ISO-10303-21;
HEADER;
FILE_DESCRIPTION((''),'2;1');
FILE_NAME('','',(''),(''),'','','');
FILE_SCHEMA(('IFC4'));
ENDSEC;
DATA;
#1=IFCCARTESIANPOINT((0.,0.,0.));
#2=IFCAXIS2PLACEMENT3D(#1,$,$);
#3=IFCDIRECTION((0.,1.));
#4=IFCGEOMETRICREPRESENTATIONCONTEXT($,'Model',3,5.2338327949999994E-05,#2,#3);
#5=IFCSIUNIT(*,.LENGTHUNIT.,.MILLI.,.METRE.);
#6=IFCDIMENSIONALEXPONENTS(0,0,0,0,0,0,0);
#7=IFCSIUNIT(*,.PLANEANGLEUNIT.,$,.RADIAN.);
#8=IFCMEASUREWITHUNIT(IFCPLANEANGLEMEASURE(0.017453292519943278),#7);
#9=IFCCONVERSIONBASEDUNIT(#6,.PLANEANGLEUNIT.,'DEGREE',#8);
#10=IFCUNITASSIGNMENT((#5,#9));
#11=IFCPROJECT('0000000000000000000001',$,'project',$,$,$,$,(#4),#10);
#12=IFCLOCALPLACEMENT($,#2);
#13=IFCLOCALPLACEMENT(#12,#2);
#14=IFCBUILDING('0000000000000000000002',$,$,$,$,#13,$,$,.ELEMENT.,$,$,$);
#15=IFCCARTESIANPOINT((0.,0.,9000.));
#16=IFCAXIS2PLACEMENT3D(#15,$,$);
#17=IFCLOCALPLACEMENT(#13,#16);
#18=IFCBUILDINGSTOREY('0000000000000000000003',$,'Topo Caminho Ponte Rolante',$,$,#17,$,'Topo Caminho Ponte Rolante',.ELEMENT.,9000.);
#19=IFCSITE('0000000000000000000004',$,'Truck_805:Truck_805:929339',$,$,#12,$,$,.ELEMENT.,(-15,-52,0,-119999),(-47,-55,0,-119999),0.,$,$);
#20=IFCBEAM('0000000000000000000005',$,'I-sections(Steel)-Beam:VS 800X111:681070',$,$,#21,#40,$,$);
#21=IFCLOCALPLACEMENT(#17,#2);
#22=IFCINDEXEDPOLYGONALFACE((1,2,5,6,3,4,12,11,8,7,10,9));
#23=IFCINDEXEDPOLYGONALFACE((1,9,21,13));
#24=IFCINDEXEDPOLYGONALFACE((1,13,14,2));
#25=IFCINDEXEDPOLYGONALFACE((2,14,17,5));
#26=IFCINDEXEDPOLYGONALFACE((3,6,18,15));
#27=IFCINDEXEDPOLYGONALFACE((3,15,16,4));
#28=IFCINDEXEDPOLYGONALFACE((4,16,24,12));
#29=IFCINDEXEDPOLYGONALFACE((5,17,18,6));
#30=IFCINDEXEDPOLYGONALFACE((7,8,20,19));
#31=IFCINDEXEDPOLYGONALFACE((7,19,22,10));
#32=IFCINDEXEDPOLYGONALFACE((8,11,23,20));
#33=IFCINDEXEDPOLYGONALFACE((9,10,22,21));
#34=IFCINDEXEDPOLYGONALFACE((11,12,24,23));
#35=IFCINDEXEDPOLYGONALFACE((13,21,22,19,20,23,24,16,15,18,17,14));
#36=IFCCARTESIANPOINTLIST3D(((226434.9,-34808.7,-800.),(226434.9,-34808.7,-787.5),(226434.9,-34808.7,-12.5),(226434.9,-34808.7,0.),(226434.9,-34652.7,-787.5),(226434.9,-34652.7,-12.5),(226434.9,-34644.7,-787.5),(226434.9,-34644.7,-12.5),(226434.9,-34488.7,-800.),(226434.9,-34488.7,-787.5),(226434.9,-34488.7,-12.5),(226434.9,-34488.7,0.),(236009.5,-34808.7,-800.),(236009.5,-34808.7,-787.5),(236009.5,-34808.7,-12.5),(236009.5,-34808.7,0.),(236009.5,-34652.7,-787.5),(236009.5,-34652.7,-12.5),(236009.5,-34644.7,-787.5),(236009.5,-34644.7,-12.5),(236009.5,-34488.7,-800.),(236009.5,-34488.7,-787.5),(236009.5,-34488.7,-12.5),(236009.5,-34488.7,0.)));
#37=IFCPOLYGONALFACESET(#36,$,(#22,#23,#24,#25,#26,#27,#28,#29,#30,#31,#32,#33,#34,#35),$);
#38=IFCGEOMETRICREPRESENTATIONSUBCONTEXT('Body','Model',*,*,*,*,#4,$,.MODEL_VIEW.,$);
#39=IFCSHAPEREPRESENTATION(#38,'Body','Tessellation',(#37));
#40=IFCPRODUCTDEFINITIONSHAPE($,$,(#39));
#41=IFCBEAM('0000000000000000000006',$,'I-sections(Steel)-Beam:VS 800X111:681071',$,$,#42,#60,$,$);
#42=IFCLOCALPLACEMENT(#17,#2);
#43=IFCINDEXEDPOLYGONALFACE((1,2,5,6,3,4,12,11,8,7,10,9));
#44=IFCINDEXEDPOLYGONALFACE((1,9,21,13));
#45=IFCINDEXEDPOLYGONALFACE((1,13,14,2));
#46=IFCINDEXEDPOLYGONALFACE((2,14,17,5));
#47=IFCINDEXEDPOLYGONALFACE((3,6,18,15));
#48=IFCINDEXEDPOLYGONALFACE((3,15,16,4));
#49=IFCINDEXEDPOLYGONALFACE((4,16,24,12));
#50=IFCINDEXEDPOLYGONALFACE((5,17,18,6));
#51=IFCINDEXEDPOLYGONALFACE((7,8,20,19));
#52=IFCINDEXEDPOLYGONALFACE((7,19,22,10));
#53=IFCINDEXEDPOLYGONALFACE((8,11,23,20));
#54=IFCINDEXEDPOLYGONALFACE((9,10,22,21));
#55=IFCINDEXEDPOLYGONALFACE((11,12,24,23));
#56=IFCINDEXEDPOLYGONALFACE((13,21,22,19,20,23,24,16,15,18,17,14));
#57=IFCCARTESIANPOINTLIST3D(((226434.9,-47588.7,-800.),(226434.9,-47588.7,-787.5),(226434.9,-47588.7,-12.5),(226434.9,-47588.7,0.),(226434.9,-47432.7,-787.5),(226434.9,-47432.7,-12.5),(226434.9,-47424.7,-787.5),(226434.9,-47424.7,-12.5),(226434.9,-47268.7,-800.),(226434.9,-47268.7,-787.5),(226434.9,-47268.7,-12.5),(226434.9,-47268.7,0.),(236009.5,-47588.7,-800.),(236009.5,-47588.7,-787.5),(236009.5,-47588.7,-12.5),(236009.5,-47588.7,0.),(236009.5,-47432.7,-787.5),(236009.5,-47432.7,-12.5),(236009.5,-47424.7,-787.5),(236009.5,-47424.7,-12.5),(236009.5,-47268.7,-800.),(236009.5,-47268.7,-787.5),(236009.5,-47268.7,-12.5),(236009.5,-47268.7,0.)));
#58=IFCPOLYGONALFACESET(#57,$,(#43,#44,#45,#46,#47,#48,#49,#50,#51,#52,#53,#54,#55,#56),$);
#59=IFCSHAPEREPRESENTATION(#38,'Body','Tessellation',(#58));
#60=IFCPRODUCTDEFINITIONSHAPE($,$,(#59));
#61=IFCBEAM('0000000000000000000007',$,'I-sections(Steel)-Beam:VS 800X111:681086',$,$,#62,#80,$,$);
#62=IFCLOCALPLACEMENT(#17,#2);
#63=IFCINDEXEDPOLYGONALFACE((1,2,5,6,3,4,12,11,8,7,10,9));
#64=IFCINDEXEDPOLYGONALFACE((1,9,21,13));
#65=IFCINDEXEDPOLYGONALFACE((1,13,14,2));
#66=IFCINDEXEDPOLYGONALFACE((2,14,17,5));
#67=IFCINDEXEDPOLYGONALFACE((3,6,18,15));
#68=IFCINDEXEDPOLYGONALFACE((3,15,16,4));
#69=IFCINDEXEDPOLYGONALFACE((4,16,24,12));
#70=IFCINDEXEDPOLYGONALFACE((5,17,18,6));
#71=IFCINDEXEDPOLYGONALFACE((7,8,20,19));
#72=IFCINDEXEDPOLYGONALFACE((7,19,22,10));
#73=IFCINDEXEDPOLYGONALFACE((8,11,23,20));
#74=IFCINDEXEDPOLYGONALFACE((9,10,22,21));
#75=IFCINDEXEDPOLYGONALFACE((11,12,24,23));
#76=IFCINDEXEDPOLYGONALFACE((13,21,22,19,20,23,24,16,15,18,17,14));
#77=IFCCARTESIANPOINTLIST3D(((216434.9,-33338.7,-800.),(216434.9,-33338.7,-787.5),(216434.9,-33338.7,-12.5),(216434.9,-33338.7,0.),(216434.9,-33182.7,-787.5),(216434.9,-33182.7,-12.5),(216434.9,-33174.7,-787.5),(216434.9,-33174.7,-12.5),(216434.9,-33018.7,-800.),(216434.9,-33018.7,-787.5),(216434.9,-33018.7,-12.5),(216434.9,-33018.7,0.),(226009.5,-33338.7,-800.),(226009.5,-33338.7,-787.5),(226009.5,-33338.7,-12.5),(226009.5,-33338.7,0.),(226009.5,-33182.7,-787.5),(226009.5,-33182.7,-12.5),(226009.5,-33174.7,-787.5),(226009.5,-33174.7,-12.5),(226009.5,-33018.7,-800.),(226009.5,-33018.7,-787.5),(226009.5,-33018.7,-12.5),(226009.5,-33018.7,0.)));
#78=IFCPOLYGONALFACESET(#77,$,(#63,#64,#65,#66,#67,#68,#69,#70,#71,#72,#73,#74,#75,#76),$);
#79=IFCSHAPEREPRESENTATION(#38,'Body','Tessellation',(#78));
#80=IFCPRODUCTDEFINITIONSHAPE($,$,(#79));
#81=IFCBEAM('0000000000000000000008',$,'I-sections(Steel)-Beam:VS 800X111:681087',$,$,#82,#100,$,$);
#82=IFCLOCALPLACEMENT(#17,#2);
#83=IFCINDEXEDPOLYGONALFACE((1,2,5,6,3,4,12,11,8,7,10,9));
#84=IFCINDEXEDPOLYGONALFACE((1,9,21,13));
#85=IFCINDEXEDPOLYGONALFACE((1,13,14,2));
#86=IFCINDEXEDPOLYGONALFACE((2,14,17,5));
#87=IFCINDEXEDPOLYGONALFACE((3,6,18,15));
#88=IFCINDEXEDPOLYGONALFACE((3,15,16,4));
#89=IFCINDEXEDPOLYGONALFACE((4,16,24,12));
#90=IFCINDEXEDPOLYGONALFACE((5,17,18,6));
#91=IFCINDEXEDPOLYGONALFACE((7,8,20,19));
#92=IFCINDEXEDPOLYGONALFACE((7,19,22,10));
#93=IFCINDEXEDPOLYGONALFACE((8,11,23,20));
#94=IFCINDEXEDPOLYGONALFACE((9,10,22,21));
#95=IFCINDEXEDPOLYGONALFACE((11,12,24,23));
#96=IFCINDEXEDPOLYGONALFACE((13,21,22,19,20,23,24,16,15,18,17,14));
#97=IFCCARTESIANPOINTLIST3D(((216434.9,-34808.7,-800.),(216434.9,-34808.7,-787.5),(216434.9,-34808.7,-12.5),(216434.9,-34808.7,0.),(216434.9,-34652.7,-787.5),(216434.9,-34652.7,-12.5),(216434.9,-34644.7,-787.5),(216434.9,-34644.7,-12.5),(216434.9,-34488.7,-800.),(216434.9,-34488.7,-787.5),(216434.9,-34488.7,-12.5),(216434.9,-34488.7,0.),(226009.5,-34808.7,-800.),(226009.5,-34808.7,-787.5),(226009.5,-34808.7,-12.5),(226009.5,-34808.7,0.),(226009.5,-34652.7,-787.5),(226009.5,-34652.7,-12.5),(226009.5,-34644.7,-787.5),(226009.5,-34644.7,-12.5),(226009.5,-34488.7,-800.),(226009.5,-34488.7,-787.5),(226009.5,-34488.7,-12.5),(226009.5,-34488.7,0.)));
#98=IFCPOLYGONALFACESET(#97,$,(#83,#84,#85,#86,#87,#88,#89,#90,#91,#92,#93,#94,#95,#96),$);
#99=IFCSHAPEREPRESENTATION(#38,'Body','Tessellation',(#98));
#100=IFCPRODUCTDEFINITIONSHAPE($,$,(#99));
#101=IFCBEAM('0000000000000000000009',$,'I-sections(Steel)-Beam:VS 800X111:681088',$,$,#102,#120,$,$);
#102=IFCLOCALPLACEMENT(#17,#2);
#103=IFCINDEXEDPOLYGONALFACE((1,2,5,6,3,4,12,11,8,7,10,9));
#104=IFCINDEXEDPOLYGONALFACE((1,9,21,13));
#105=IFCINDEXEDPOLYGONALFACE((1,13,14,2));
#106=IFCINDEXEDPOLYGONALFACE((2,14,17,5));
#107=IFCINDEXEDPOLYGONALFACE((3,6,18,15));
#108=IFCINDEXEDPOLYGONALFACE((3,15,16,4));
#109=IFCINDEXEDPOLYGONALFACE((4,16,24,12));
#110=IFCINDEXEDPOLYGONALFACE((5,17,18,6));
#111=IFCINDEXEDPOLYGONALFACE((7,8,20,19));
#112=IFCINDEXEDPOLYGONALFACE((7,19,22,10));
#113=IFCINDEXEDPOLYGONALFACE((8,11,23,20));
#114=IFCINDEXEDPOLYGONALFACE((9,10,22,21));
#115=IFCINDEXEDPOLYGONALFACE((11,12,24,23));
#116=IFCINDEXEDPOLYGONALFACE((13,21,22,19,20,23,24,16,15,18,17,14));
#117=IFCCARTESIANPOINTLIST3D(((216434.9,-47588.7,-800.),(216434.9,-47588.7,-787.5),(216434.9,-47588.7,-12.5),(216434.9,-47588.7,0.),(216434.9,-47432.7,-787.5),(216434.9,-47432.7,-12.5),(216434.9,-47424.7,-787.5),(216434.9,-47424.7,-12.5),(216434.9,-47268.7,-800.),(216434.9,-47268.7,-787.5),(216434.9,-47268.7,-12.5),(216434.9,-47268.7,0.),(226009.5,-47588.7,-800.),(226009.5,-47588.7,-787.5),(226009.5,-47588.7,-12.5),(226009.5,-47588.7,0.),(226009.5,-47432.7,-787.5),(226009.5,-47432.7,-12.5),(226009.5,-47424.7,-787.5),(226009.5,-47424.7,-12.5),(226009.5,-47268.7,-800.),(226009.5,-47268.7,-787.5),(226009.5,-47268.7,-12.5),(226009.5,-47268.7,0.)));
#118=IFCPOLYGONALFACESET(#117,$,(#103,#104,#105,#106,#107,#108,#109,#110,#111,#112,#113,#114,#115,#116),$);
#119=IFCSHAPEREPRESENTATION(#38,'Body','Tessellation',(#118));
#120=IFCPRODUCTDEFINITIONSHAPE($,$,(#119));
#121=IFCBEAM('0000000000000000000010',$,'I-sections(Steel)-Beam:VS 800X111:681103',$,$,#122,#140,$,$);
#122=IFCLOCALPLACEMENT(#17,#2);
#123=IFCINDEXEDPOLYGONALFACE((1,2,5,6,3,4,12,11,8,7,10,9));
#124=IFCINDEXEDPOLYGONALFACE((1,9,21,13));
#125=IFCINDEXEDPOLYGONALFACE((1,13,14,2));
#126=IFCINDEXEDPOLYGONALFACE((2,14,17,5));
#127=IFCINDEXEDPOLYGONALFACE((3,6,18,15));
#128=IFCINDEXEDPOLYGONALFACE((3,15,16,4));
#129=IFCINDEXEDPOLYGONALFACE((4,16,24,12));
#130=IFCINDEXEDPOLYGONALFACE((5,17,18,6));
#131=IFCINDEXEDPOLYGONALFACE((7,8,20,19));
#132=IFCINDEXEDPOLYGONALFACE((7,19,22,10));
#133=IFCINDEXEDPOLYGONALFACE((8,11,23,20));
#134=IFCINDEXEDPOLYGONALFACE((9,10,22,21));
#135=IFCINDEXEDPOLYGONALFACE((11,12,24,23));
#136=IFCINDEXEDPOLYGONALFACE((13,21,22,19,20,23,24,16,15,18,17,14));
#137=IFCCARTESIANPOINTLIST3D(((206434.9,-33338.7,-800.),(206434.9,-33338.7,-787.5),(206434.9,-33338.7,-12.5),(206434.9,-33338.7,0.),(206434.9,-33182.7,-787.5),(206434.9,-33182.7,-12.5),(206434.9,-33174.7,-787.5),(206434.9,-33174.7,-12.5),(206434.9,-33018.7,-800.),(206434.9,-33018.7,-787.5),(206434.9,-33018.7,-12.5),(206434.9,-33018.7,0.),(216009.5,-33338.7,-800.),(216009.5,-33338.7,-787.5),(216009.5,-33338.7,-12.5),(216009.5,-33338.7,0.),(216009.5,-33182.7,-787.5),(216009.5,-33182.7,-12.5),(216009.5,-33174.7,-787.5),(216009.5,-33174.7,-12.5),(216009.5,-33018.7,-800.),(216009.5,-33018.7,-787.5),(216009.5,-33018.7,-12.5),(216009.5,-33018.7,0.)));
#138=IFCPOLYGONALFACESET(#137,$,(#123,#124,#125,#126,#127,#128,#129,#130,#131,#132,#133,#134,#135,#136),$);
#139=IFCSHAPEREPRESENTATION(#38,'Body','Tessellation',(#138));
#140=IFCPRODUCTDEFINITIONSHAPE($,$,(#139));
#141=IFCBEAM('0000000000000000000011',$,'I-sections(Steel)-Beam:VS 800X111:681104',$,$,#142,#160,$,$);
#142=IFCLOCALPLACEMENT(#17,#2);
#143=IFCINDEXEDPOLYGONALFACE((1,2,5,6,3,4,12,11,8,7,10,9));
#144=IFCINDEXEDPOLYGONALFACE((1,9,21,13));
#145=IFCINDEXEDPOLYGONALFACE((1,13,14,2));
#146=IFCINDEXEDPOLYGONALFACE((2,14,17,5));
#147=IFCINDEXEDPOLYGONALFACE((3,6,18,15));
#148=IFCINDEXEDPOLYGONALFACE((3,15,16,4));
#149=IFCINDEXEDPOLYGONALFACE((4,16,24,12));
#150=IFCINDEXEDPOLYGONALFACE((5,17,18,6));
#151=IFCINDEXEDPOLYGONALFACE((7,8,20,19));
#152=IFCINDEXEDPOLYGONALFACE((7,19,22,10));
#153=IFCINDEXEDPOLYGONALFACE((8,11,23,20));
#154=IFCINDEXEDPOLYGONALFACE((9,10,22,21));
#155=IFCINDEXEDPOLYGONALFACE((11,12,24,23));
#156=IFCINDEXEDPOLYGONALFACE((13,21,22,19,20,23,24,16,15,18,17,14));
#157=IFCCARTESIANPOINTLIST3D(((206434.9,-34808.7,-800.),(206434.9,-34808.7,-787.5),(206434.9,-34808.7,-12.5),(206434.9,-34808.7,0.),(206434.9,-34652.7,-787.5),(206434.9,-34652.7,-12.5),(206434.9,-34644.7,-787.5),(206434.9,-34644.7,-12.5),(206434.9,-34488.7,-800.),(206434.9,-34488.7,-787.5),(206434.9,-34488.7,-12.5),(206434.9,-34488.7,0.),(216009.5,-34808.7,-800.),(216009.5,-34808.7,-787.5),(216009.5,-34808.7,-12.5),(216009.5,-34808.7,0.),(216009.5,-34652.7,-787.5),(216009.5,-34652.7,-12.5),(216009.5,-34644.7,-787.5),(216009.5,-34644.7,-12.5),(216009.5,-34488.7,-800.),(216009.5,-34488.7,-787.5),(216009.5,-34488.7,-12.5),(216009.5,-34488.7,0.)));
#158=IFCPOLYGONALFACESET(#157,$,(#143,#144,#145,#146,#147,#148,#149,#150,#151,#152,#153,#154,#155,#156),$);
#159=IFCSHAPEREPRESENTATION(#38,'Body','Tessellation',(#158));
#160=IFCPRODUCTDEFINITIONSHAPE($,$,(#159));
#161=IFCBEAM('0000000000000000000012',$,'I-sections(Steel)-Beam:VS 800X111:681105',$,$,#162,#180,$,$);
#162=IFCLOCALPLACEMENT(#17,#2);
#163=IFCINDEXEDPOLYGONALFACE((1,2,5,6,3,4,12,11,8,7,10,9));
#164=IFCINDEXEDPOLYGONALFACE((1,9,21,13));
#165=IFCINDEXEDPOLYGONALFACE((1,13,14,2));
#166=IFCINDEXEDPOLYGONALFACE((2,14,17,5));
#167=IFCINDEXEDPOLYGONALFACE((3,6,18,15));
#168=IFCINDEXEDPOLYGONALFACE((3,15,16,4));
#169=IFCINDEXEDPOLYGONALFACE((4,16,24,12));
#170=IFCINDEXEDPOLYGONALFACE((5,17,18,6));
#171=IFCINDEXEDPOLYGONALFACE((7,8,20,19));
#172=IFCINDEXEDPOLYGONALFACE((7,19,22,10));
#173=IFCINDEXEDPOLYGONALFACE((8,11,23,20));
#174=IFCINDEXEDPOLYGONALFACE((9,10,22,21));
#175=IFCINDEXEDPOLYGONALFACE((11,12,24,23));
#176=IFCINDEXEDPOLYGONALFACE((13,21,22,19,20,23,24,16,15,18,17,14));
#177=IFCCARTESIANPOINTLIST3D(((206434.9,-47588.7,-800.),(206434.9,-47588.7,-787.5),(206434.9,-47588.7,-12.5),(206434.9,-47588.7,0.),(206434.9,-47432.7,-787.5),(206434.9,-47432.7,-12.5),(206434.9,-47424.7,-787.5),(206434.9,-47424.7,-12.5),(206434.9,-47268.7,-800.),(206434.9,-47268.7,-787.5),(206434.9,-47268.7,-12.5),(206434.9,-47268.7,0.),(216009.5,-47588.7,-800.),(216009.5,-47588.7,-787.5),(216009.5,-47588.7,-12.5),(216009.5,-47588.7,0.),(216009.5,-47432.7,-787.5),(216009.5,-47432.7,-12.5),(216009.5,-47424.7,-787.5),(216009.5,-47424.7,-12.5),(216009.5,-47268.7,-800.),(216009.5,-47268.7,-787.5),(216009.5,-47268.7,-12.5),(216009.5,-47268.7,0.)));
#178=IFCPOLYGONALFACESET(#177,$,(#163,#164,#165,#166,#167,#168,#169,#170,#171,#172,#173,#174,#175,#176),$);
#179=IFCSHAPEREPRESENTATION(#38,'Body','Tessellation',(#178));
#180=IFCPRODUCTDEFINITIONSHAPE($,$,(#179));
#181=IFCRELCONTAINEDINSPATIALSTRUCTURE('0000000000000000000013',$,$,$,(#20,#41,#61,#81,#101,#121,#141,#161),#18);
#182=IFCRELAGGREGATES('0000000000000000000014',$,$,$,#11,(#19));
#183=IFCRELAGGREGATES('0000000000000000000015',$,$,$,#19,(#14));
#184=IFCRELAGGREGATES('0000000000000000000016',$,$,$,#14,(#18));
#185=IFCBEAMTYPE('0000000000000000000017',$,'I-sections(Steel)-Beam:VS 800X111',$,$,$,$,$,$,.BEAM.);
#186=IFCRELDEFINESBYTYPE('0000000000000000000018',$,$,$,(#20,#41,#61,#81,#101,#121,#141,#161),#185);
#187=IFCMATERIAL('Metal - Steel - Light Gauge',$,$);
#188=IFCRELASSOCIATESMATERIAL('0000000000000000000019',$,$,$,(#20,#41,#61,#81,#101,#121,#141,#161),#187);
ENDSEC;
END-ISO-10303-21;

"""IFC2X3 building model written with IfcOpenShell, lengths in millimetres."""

from ifc_helpers import new_model, entity, si_unit, converted_unit, direction, frame, frame_2d, origin, place, context, subcontext, project, spatial, polyline, i_section, outline, extrude, material, type_object, element, save


model = new_model("IFC2X3")

# Units and contexts
model_context = context("Model", 3, precision=5.2338327949999994e-05, world=origin(), true_north=direction((0.0, 1.0)))
body_context = subcontext(model_context, "Body", "Model", "MODEL_VIEW")
ifc_project = project(units=[si_unit("LENGTHUNIT", "METRE", prefix="MILLI"), converted_unit("PLANEANGLEUNIT", "DEGREE", entity("IfcPlaneAngleMeasure", 0.017453292519943278), si_unit("PLANEANGLEUNIT", "RADIAN"), dimensions=[0, 0, 0, 0, 0, 0, 0])], contexts=[model_context])

# Site, building, storey
site_placement = place(None, origin())
site = spatial("IfcSite", under=ifc_project, at=site_placement, Name="Truck_805:Truck_805:929339", CompositionType="ELEMENT", RefLatitude=(-15, -52, 0, -119999), RefLongitude=(-47, -55, 0, -119999), RefElevation=0.0)
building_placement = place(site_placement, origin())
building = spatial("IfcBuilding", under=site, at=building_placement, CompositionType="ELEMENT")
storey_placement = place(building_placement, frame((0.0, 0.0, 9000.0)))
storey = spatial("IfcBuildingStorey", under=building, at=storey_placement, Name="Topo Caminho Ponte Rolante", LongName="Topo Caminho Ponte Rolante", CompositionType="ELEMENT", Elevation=9000.0)

# Beams
ifc_material = material(Name="Metal - Steel - Light Gauge")
beam_type_1 = type_object("IfcBeamType", Name="I-sections(Steel)-Beam:VS 800X111", PredefinedType="BEAM")
beam_1_placement = place(storey_placement, frame((226222.2, -34648.7, 0.0)))
element("IfcBeam", 1, at=beam_1_placement, inside=storey, type_object=beam_type_1, material=ifc_material, Name="I-sections(Steel)-Beam:VS 800X111:681070", context=body_context, shape_type="SweptSolid", body=[
    extrude(outline(polyline([(387.5, -160.0), (400.0, -160.0), (400.0, 160.0), (387.5, 160.0), (387.5, 4.0), (-387.5, 4.0), (-387.5, 160.0), (-400.0, 160.0), (-400.0, -160.0), (-387.5, -160.0), (-387.5, -4.0), (387.5, -4.0), (387.5, -160.0)])), frame((212.7, 0.0, -400.0), z_axis=(1.0, 0.0, 0.0), x_axis=(0.0, 0.0, -1.0)), (0.0, 0.0, 1.0), 9574.6),
])
beam_2_placement = place(storey_placement, frame((226222.2, -47428.7, 0.0)))
element("IfcBeam", 2, at=beam_2_placement, inside=storey, type_object=beam_type_1, material=ifc_material, Name="I-sections(Steel)-Beam:VS 800X111:681071", context=body_context, shape_type="SweptSolid", body=[
    extrude(i_section(OverallWidth=320.0, OverallDepth=800.0, WebThickness=8.0, FlangeThickness=12.5, at=frame_2d((0.0, 0.0), x_axis=(0.0, 1.0))), frame((212.7, 0.0, -400.0), z_axis=(1.0, 0.0, 0.0), x_axis=(0.0, 0.0, -1.0)), (0.0, 0.0, 1.0), 9574.6),
])
beam_3_placement = place(storey_placement, frame((216222.2, -33178.7, 0.0)))
element("IfcBeam", 3, at=beam_3_placement, inside=storey, type_object=beam_type_1, material=ifc_material, Name="I-sections(Steel)-Beam:VS 800X111:681086", context=body_context, shape_type="SweptSolid", body=[
    extrude(i_section(OverallWidth=320.0, OverallDepth=800.0, WebThickness=8.0, FlangeThickness=12.5, at=frame_2d((0.0, 0.0), x_axis=(0.0, 1.0))), frame((212.7, 0.0, -400.0), z_axis=(1.0, 0.0, 0.0), x_axis=(0.0, 0.0, -1.0)), (0.0, 0.0, 1.0), 9574.6),
])
beam_4_placement = place(storey_placement, frame((216222.2, -34648.7, 0.0)))
element("IfcBeam", 4, at=beam_4_placement, inside=storey, type_object=beam_type_1, material=ifc_material, Name="I-sections(Steel)-Beam:VS 800X111:681087", context=body_context, shape_type="SweptSolid", body=[
    extrude(outline(polyline([(387.5, -160.0), (400.0, -160.0), (400.0, 160.0), (387.5, 160.0), (387.5, 4.0), (-387.5, 4.0), (-387.5, 160.0), (-400.0, 160.0), (-400.0, -160.0), (-387.5, -160.0), (-387.5, -4.0), (387.5, -4.0), (387.5, -160.0)])), frame((212.7, 0.0, -400.0), z_axis=(1.0, 0.0, 0.0), x_axis=(0.0, 0.0, -1.0)), (0.0, 0.0, 1.0), 9574.6),
])
beam_5_placement = place(storey_placement, frame((216222.2, -47428.7, 0.0)))
element("IfcBeam", 5, at=beam_5_placement, inside=storey, type_object=beam_type_1, material=ifc_material, Name="I-sections(Steel)-Beam:VS 800X111:681088", context=body_context, shape_type="SweptSolid", body=[
    extrude(i_section(OverallWidth=320.0, OverallDepth=800.0, WebThickness=8.0, FlangeThickness=12.5, at=frame_2d((0.0, 0.0), x_axis=(0.0, 1.0))), frame((212.7, 0.0, -400.0), z_axis=(1.0, 0.0, 0.0), x_axis=(0.0, 0.0, -1.0)), (0.0, 0.0, 1.0), 9574.6),
])
beam_6_placement = place(storey_placement, frame((206222.2, -33178.7, 0.0)))
element("IfcBeam", 6, at=beam_6_placement, inside=storey, type_object=beam_type_1, material=ifc_material, Name="I-sections(Steel)-Beam:VS 800X111:681103", context=body_context, shape_type="SweptSolid", body=[
    extrude(i_section(OverallWidth=320.0, OverallDepth=800.0, WebThickness=8.0, FlangeThickness=12.5, at=frame_2d((0.0, 0.0), x_axis=(0.0, 1.0))), frame((212.7, 0.0, -400.0), z_axis=(1.0, 0.0, 0.0), x_axis=(0.0, 0.0, -1.0)), (0.0, 0.0, 1.0), 9574.6),
])
beam_7_placement = place(storey_placement, frame((206222.2, -34648.7, 0.0)))
element("IfcBeam", 7, at=beam_7_placement, inside=storey, type_object=beam_type_1, material=ifc_material, Name="I-sections(Steel)-Beam:VS 800X111:681104", context=body_context, shape_type="SweptSolid", body=[
    extrude(outline(polyline([(387.5, -160.0), (400.0, -160.0), (400.0, 160.0), (387.5, 160.0), (387.5, 4.0), (-387.5, 4.0), (-387.5, 160.0), (-400.0, 160.0), (-400.0, -160.0), (-387.5, -160.0), (-387.5, -4.0), (387.5, -4.0), (387.5, -160.0)])), frame((212.7, 0.0, -400.0), z_axis=(1.0, 0.0, 0.0), x_axis=(0.0, 0.0, -1.0)), (0.0, 0.0, 1.0), 9574.6),
])
beam_8_placement = place(storey_placement, frame((206222.2, -47428.7, 0.0)))
element("IfcBeam", 8, at=beam_8_placement, inside=storey, type_object=beam_type_1, material=ifc_material, Name="I-sections(Steel)-Beam:VS 800X111:681105", context=body_context, shape_type="SweptSolid", body=[
    extrude(i_section(OverallWidth=320.0, OverallDepth=800.0, WebThickness=8.0, FlangeThickness=12.5, at=frame_2d((0.0, 0.0), x_axis=(0.0, 1.0))), frame((212.7, 0.0, -400.0), z_axis=(1.0, 0.0, 0.0), x_axis=(0.0, 0.0, -1.0)), (0.0, 0.0, 1.0), 9574.6),
])

save(model, "model.ifc")
